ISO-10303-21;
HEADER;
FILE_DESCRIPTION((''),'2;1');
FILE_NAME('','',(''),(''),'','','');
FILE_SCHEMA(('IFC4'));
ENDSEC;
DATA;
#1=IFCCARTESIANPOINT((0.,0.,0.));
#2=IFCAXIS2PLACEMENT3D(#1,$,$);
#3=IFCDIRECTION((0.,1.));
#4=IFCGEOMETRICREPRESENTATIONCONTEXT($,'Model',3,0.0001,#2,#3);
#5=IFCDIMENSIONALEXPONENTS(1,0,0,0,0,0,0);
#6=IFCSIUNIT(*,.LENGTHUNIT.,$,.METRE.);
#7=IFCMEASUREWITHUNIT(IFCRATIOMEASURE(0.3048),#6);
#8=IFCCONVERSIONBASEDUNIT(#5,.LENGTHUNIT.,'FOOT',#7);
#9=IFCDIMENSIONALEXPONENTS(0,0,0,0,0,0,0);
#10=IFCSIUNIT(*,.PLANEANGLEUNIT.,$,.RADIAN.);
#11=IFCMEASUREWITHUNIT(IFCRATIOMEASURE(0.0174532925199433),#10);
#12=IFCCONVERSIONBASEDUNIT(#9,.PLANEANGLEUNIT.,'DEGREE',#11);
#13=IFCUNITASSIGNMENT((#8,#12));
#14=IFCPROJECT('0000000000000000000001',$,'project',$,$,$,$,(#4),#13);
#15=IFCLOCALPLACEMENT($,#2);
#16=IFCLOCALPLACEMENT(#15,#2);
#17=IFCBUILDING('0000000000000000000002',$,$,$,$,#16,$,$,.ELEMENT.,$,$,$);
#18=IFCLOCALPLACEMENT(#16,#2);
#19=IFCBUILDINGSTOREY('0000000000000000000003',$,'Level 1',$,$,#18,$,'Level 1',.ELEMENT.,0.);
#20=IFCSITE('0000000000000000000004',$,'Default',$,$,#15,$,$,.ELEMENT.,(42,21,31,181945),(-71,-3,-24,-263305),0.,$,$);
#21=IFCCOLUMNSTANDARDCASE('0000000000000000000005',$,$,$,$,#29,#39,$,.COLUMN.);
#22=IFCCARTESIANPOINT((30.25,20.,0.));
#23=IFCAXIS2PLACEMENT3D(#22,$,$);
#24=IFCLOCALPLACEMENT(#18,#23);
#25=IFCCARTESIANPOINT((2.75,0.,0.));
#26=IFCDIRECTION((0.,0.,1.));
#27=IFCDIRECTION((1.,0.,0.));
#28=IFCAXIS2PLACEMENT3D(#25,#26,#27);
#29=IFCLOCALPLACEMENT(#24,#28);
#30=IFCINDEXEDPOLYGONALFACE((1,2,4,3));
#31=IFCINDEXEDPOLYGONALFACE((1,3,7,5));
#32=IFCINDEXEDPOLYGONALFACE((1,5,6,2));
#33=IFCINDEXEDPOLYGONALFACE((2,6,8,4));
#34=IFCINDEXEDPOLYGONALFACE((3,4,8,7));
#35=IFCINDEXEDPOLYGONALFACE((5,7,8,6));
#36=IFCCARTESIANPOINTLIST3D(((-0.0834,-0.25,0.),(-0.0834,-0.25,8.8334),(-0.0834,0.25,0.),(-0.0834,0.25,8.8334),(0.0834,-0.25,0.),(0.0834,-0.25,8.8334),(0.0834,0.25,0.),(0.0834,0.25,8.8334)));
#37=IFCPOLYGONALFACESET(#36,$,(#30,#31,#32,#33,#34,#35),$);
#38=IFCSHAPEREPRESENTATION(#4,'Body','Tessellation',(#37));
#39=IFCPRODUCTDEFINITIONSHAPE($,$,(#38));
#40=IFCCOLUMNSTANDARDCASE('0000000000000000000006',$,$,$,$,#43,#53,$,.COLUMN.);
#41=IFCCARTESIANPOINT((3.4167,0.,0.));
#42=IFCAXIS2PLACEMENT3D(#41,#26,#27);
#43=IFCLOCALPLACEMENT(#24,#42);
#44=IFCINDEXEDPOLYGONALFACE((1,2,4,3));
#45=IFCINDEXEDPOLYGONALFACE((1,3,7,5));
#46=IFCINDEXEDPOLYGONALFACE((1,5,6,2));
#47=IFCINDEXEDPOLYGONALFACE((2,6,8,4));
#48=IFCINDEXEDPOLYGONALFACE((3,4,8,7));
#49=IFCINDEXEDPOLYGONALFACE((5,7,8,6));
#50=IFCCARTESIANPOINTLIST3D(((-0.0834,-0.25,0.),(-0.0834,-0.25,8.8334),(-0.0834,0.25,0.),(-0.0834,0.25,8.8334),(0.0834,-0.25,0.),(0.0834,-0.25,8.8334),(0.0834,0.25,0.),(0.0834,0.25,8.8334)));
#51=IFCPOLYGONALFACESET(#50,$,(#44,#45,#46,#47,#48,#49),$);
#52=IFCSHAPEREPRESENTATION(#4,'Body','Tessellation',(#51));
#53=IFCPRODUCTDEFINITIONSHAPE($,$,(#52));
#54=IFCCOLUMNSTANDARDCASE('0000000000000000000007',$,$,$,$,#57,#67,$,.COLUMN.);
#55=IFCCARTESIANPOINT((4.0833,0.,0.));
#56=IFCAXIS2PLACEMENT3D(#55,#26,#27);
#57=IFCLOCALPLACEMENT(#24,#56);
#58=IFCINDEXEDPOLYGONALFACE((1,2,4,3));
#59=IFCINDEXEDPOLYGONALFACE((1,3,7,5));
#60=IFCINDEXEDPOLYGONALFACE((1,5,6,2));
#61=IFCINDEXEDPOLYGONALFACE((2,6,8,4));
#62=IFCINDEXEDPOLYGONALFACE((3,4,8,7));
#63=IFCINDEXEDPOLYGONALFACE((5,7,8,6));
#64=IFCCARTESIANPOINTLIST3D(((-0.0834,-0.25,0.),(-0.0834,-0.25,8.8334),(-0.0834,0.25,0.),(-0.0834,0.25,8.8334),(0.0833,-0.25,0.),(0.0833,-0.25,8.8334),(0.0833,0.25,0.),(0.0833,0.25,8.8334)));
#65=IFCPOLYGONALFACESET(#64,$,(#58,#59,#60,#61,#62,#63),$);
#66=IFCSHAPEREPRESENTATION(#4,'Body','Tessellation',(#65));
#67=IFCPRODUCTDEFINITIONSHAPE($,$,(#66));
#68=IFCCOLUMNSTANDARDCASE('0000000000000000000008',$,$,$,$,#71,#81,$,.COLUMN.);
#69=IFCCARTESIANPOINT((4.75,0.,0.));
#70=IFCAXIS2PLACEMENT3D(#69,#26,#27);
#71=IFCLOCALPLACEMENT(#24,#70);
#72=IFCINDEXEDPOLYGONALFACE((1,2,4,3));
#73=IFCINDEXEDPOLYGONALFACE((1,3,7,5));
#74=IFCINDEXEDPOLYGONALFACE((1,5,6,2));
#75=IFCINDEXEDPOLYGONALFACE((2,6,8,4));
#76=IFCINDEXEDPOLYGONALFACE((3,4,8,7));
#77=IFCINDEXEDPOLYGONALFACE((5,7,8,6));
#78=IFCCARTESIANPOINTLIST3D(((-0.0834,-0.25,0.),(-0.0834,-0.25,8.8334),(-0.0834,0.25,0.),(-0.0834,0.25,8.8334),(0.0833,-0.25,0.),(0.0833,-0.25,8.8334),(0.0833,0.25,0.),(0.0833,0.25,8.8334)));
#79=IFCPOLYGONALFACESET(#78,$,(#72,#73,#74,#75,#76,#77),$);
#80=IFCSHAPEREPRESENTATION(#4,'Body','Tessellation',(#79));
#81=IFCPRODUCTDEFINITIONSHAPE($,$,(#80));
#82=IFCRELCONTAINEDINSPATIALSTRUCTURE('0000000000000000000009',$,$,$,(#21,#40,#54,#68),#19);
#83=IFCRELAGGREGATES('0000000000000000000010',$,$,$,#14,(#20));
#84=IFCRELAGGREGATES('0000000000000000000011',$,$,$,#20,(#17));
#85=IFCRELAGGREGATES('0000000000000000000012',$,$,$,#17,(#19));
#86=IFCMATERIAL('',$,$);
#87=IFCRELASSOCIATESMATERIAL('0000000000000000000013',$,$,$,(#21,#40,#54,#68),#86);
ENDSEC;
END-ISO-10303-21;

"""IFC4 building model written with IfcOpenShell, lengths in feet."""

from ifc_helpers import new_model, entity, si_unit, converted_unit, direction, frame, origin, place, context, project, spatial, rectangle, extrude, material, element, save


model = new_model("IFC4")

# Units and contexts
model_context = context("Model", 3, precision=0.0001, world=origin(), true_north=direction((0.0, 1.0)))
ifc_project = project(units=[converted_unit("LENGTHUNIT", "FOOT", entity("IfcRatioMeasure", 0.3048), si_unit("LENGTHUNIT", "METRE"), dimensions=[1, 0, 0, 0, 0, 0, 0]), converted_unit("PLANEANGLEUNIT", "DEGREE", entity("IfcRatioMeasure", 0.0174532925199433), si_unit("PLANEANGLEUNIT", "RADIAN"), dimensions=[0, 0, 0, 0, 0, 0, 0])], contexts=[model_context])

# Site, building, storey
site_placement = place(None, origin())
site = spatial("IfcSite", under=ifc_project, at=site_placement, Name="Default", CompositionType="ELEMENT", RefLatitude=(42, 21, 31, 181945), RefLongitude=(-71, -3, -24, -263305), RefElevation=0.0)
building_placement = place(site_placement, origin())
building = spatial("IfcBuilding", under=site, at=building_placement, CompositionType="ELEMENT")
storey_placement = place(building_placement, origin())
storey = spatial("IfcBuildingStorey", under=building, at=storey_placement, Name="Level 1", LongName="Level 1", CompositionType="ELEMENT", Elevation=0.0)

# Columns
ifc_material_1 = material(Name="")
placement_1 = place(storey_placement, frame((30.25, 20.0, 0.0)))
for number, where, z_axis, x_axis in (
    (1, (2.75, 0.0, 0.0), (0.0, 0.0, 1.0), (1.0, 0.0, 0.0)),
    (2, (3.4167, 0.0, 0.0), (0.0, 0.0, 1.0), (1.0, 0.0, 0.0)),
    (3, (4.0833, 0.0, 0.0), (0.0, 0.0, 1.0), (1.0, 0.0, 0.0)),
    (4, (4.75, 0.0, 0.0), (0.0, 0.0, 1.0), (1.0, 0.0, 0.0)),
):
    element("IfcColumnStandardCase", number, at=place(placement_1, frame(where, z_axis=z_axis, x_axis=x_axis)), inside=storey, material=ifc_material_1, PredefinedType="COLUMN", context=model_context, shape_type="SweptSolid", body=[
        extrude(rectangle(XDim=0.1667, YDim=0.5), origin(), (0.0, 0.0, 1.0), 8.8334),
    ])

save(model, "model.ifc")
